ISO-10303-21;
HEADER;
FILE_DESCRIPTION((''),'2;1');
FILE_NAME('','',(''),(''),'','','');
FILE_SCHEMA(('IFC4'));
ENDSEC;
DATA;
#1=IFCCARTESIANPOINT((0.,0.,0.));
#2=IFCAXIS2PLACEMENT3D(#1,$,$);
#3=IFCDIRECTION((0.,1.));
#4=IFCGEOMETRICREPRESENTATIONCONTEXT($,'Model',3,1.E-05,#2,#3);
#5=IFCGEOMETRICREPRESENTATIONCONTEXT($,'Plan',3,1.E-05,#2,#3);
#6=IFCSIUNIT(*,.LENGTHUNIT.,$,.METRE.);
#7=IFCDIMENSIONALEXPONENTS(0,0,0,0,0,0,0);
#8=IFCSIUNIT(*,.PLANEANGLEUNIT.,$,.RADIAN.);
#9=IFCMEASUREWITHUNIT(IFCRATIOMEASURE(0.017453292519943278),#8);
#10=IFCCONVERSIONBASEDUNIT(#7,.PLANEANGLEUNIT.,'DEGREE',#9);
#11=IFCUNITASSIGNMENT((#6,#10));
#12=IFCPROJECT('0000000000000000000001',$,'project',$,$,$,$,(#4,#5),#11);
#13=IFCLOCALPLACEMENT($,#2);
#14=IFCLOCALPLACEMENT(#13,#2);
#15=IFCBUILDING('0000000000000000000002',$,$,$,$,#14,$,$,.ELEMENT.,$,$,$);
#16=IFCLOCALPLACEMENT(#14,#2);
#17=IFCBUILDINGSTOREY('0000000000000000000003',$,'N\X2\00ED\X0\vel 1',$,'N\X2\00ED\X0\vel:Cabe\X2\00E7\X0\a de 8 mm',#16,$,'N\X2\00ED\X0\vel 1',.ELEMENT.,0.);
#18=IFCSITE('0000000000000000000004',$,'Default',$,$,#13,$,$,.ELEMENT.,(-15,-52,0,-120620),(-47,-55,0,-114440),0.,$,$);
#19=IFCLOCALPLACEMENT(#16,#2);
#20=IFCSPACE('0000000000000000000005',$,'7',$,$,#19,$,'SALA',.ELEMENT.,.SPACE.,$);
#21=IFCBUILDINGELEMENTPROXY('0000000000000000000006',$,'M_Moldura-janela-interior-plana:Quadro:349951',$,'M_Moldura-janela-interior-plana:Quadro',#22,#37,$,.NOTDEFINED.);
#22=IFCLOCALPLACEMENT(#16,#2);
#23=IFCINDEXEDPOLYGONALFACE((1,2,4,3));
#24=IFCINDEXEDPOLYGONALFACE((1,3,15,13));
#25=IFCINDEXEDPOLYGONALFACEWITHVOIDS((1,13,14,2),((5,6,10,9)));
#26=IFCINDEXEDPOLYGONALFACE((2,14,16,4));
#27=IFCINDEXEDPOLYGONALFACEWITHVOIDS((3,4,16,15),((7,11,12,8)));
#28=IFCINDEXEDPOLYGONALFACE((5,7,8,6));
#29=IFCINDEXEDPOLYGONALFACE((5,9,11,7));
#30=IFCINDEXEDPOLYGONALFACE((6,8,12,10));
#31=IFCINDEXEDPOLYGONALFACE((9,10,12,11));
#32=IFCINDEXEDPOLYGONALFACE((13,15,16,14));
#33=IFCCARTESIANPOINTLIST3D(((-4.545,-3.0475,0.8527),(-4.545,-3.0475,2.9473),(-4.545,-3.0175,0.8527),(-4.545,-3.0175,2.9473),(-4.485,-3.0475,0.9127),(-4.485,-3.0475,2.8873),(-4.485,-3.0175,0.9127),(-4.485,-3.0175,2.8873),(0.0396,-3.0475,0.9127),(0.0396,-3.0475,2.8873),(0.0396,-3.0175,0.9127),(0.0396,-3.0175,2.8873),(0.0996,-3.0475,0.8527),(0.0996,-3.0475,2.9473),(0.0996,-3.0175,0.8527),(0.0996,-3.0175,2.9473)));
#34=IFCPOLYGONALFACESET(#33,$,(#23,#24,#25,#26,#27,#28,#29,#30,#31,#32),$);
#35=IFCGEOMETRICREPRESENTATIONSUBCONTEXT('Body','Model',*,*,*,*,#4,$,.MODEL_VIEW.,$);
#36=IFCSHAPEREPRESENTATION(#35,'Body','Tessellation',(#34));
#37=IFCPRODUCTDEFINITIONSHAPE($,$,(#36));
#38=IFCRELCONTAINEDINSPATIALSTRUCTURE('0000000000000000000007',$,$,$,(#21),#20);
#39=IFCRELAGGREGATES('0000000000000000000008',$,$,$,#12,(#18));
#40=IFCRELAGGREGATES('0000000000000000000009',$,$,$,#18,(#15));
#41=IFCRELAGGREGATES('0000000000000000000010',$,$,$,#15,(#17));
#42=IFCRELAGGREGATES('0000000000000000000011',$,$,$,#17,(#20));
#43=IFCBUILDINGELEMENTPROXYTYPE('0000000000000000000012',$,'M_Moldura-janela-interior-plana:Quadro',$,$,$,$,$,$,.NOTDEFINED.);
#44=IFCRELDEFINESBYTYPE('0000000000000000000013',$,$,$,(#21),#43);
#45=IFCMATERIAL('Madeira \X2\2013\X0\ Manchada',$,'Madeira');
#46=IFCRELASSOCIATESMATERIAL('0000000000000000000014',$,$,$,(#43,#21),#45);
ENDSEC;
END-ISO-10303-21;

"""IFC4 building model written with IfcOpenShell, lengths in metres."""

from ifc_helpers import new_model, entity, si_unit, converted_unit, direction, frame, origin, place, context, subcontext, project, spatial, indexed_curve, outline, extrude, source, transform, mapped, material, type_object, type_shapes, element, save


model = new_model("IFC4")

# Units and contexts
model_context = context("Model", 3, precision=1e-05, world=origin(), true_north=direction((0.0, 1.0)))
plan_context = context("Plan", 3, precision=1e-05, world=origin(), true_north=direction((0.0, 1.0)))
body_context = subcontext(model_context, "Body", "Model", "MODEL_VIEW")
ifc_project = project(units=[si_unit("LENGTHUNIT", "METRE"), converted_unit("PLANEANGLEUNIT", "DEGREE", entity("IfcRatioMeasure", 0.017453292519943278), si_unit("PLANEANGLEUNIT", "RADIAN"), dimensions=[0, 0, 0, 0, 0, 0, 0])], contexts=[model_context, plan_context])

# Site, building, storey
site_placement = place(None, origin())
site = spatial("IfcSite", under=ifc_project, at=site_placement, Name="Default", CompositionType="ELEMENT", RefLatitude=(-15, -52, 0, -120620), RefLongitude=(-47, -55, 0, -114440), RefElevation=0.0)
building_placement = place(site_placement, origin())
building = spatial("IfcBuilding", under=site, at=building_placement, CompositionType="ELEMENT")
storey_placement = place(building_placement, origin())
storey = spatial("IfcBuildingStorey", under=building, at=storey_placement, Name="Nível 1", ObjectType="Nível:Cabeça de 8 mm", LongName="Nível 1", CompositionType="ELEMENT", Elevation=0.0)

# Shared definitions
ifc_material_1 = material(Name="Madeira – Manchada", Category="Madeira")

# Shared definitions
space_1_placement = place(storey_placement, origin())
space_1 = spatial("IfcSpace", under=storey, at=space_1_placement, Name="7", LongName="SALA", CompositionType="ELEMENT", PredefinedType="SPACE")

# Building element proxy
building_element_proxy_type_1 = type_object("IfcBuildingElementProxyType", Name="M_Moldura-janela-interior-plana:Quadro", PredefinedType="NOTDEFINED", material=ifc_material_1)
shared_shape_1 = source(origin(), body_context, "Body", "SweptSolid", [
    extrude(outline(indexed_curve([(-2.3223, -1.0473), (2.3223, -1.0473), (2.3223, 1.0473), (-2.3223, 1.0473), (-2.3223, -1.0473)], self_intersect=False), holes=[indexed_curve([(-2.2623, -0.9873), (-2.2623, 0.9873), (2.2623, 0.9873), (2.2623, -0.9873), (-2.2623, -0.9873)], self_intersect=False)]), frame((0.0, -1.0, 0.0), z_axis=(0.0, 0.0, 1.0), x_axis=(-1.0, 0.0, 0.0)), (0.0, 0.0, 1.0), 0.03),
])
type_shapes(building_element_proxy_type_1, [shared_shape_1])
proxy_1_placement = place(space_1_placement, frame((-2.2227, -3.0475, 2.9), z_axis=(0.0, 1.0, 0.0), x_axis=(-1.0, 0.0, 0.0)))
element("IfcBuildingElementProxy", 1, at=proxy_1_placement, inside=space_1, type_object=building_element_proxy_type_1, material=ifc_material_1, Name="M_Moldura-janela-interior-plana:Quadro:349951", ObjectType="M_Moldura-janela-interior-plana:Quadro", PredefinedType="NOTDEFINED", context=body_context, shape_type="MappedRepresentation", body=[
    mapped(shared_shape_1, transform((0.0, 0.0, 0.0), scale=1.0)),
])

save(model, "model.ifc")
